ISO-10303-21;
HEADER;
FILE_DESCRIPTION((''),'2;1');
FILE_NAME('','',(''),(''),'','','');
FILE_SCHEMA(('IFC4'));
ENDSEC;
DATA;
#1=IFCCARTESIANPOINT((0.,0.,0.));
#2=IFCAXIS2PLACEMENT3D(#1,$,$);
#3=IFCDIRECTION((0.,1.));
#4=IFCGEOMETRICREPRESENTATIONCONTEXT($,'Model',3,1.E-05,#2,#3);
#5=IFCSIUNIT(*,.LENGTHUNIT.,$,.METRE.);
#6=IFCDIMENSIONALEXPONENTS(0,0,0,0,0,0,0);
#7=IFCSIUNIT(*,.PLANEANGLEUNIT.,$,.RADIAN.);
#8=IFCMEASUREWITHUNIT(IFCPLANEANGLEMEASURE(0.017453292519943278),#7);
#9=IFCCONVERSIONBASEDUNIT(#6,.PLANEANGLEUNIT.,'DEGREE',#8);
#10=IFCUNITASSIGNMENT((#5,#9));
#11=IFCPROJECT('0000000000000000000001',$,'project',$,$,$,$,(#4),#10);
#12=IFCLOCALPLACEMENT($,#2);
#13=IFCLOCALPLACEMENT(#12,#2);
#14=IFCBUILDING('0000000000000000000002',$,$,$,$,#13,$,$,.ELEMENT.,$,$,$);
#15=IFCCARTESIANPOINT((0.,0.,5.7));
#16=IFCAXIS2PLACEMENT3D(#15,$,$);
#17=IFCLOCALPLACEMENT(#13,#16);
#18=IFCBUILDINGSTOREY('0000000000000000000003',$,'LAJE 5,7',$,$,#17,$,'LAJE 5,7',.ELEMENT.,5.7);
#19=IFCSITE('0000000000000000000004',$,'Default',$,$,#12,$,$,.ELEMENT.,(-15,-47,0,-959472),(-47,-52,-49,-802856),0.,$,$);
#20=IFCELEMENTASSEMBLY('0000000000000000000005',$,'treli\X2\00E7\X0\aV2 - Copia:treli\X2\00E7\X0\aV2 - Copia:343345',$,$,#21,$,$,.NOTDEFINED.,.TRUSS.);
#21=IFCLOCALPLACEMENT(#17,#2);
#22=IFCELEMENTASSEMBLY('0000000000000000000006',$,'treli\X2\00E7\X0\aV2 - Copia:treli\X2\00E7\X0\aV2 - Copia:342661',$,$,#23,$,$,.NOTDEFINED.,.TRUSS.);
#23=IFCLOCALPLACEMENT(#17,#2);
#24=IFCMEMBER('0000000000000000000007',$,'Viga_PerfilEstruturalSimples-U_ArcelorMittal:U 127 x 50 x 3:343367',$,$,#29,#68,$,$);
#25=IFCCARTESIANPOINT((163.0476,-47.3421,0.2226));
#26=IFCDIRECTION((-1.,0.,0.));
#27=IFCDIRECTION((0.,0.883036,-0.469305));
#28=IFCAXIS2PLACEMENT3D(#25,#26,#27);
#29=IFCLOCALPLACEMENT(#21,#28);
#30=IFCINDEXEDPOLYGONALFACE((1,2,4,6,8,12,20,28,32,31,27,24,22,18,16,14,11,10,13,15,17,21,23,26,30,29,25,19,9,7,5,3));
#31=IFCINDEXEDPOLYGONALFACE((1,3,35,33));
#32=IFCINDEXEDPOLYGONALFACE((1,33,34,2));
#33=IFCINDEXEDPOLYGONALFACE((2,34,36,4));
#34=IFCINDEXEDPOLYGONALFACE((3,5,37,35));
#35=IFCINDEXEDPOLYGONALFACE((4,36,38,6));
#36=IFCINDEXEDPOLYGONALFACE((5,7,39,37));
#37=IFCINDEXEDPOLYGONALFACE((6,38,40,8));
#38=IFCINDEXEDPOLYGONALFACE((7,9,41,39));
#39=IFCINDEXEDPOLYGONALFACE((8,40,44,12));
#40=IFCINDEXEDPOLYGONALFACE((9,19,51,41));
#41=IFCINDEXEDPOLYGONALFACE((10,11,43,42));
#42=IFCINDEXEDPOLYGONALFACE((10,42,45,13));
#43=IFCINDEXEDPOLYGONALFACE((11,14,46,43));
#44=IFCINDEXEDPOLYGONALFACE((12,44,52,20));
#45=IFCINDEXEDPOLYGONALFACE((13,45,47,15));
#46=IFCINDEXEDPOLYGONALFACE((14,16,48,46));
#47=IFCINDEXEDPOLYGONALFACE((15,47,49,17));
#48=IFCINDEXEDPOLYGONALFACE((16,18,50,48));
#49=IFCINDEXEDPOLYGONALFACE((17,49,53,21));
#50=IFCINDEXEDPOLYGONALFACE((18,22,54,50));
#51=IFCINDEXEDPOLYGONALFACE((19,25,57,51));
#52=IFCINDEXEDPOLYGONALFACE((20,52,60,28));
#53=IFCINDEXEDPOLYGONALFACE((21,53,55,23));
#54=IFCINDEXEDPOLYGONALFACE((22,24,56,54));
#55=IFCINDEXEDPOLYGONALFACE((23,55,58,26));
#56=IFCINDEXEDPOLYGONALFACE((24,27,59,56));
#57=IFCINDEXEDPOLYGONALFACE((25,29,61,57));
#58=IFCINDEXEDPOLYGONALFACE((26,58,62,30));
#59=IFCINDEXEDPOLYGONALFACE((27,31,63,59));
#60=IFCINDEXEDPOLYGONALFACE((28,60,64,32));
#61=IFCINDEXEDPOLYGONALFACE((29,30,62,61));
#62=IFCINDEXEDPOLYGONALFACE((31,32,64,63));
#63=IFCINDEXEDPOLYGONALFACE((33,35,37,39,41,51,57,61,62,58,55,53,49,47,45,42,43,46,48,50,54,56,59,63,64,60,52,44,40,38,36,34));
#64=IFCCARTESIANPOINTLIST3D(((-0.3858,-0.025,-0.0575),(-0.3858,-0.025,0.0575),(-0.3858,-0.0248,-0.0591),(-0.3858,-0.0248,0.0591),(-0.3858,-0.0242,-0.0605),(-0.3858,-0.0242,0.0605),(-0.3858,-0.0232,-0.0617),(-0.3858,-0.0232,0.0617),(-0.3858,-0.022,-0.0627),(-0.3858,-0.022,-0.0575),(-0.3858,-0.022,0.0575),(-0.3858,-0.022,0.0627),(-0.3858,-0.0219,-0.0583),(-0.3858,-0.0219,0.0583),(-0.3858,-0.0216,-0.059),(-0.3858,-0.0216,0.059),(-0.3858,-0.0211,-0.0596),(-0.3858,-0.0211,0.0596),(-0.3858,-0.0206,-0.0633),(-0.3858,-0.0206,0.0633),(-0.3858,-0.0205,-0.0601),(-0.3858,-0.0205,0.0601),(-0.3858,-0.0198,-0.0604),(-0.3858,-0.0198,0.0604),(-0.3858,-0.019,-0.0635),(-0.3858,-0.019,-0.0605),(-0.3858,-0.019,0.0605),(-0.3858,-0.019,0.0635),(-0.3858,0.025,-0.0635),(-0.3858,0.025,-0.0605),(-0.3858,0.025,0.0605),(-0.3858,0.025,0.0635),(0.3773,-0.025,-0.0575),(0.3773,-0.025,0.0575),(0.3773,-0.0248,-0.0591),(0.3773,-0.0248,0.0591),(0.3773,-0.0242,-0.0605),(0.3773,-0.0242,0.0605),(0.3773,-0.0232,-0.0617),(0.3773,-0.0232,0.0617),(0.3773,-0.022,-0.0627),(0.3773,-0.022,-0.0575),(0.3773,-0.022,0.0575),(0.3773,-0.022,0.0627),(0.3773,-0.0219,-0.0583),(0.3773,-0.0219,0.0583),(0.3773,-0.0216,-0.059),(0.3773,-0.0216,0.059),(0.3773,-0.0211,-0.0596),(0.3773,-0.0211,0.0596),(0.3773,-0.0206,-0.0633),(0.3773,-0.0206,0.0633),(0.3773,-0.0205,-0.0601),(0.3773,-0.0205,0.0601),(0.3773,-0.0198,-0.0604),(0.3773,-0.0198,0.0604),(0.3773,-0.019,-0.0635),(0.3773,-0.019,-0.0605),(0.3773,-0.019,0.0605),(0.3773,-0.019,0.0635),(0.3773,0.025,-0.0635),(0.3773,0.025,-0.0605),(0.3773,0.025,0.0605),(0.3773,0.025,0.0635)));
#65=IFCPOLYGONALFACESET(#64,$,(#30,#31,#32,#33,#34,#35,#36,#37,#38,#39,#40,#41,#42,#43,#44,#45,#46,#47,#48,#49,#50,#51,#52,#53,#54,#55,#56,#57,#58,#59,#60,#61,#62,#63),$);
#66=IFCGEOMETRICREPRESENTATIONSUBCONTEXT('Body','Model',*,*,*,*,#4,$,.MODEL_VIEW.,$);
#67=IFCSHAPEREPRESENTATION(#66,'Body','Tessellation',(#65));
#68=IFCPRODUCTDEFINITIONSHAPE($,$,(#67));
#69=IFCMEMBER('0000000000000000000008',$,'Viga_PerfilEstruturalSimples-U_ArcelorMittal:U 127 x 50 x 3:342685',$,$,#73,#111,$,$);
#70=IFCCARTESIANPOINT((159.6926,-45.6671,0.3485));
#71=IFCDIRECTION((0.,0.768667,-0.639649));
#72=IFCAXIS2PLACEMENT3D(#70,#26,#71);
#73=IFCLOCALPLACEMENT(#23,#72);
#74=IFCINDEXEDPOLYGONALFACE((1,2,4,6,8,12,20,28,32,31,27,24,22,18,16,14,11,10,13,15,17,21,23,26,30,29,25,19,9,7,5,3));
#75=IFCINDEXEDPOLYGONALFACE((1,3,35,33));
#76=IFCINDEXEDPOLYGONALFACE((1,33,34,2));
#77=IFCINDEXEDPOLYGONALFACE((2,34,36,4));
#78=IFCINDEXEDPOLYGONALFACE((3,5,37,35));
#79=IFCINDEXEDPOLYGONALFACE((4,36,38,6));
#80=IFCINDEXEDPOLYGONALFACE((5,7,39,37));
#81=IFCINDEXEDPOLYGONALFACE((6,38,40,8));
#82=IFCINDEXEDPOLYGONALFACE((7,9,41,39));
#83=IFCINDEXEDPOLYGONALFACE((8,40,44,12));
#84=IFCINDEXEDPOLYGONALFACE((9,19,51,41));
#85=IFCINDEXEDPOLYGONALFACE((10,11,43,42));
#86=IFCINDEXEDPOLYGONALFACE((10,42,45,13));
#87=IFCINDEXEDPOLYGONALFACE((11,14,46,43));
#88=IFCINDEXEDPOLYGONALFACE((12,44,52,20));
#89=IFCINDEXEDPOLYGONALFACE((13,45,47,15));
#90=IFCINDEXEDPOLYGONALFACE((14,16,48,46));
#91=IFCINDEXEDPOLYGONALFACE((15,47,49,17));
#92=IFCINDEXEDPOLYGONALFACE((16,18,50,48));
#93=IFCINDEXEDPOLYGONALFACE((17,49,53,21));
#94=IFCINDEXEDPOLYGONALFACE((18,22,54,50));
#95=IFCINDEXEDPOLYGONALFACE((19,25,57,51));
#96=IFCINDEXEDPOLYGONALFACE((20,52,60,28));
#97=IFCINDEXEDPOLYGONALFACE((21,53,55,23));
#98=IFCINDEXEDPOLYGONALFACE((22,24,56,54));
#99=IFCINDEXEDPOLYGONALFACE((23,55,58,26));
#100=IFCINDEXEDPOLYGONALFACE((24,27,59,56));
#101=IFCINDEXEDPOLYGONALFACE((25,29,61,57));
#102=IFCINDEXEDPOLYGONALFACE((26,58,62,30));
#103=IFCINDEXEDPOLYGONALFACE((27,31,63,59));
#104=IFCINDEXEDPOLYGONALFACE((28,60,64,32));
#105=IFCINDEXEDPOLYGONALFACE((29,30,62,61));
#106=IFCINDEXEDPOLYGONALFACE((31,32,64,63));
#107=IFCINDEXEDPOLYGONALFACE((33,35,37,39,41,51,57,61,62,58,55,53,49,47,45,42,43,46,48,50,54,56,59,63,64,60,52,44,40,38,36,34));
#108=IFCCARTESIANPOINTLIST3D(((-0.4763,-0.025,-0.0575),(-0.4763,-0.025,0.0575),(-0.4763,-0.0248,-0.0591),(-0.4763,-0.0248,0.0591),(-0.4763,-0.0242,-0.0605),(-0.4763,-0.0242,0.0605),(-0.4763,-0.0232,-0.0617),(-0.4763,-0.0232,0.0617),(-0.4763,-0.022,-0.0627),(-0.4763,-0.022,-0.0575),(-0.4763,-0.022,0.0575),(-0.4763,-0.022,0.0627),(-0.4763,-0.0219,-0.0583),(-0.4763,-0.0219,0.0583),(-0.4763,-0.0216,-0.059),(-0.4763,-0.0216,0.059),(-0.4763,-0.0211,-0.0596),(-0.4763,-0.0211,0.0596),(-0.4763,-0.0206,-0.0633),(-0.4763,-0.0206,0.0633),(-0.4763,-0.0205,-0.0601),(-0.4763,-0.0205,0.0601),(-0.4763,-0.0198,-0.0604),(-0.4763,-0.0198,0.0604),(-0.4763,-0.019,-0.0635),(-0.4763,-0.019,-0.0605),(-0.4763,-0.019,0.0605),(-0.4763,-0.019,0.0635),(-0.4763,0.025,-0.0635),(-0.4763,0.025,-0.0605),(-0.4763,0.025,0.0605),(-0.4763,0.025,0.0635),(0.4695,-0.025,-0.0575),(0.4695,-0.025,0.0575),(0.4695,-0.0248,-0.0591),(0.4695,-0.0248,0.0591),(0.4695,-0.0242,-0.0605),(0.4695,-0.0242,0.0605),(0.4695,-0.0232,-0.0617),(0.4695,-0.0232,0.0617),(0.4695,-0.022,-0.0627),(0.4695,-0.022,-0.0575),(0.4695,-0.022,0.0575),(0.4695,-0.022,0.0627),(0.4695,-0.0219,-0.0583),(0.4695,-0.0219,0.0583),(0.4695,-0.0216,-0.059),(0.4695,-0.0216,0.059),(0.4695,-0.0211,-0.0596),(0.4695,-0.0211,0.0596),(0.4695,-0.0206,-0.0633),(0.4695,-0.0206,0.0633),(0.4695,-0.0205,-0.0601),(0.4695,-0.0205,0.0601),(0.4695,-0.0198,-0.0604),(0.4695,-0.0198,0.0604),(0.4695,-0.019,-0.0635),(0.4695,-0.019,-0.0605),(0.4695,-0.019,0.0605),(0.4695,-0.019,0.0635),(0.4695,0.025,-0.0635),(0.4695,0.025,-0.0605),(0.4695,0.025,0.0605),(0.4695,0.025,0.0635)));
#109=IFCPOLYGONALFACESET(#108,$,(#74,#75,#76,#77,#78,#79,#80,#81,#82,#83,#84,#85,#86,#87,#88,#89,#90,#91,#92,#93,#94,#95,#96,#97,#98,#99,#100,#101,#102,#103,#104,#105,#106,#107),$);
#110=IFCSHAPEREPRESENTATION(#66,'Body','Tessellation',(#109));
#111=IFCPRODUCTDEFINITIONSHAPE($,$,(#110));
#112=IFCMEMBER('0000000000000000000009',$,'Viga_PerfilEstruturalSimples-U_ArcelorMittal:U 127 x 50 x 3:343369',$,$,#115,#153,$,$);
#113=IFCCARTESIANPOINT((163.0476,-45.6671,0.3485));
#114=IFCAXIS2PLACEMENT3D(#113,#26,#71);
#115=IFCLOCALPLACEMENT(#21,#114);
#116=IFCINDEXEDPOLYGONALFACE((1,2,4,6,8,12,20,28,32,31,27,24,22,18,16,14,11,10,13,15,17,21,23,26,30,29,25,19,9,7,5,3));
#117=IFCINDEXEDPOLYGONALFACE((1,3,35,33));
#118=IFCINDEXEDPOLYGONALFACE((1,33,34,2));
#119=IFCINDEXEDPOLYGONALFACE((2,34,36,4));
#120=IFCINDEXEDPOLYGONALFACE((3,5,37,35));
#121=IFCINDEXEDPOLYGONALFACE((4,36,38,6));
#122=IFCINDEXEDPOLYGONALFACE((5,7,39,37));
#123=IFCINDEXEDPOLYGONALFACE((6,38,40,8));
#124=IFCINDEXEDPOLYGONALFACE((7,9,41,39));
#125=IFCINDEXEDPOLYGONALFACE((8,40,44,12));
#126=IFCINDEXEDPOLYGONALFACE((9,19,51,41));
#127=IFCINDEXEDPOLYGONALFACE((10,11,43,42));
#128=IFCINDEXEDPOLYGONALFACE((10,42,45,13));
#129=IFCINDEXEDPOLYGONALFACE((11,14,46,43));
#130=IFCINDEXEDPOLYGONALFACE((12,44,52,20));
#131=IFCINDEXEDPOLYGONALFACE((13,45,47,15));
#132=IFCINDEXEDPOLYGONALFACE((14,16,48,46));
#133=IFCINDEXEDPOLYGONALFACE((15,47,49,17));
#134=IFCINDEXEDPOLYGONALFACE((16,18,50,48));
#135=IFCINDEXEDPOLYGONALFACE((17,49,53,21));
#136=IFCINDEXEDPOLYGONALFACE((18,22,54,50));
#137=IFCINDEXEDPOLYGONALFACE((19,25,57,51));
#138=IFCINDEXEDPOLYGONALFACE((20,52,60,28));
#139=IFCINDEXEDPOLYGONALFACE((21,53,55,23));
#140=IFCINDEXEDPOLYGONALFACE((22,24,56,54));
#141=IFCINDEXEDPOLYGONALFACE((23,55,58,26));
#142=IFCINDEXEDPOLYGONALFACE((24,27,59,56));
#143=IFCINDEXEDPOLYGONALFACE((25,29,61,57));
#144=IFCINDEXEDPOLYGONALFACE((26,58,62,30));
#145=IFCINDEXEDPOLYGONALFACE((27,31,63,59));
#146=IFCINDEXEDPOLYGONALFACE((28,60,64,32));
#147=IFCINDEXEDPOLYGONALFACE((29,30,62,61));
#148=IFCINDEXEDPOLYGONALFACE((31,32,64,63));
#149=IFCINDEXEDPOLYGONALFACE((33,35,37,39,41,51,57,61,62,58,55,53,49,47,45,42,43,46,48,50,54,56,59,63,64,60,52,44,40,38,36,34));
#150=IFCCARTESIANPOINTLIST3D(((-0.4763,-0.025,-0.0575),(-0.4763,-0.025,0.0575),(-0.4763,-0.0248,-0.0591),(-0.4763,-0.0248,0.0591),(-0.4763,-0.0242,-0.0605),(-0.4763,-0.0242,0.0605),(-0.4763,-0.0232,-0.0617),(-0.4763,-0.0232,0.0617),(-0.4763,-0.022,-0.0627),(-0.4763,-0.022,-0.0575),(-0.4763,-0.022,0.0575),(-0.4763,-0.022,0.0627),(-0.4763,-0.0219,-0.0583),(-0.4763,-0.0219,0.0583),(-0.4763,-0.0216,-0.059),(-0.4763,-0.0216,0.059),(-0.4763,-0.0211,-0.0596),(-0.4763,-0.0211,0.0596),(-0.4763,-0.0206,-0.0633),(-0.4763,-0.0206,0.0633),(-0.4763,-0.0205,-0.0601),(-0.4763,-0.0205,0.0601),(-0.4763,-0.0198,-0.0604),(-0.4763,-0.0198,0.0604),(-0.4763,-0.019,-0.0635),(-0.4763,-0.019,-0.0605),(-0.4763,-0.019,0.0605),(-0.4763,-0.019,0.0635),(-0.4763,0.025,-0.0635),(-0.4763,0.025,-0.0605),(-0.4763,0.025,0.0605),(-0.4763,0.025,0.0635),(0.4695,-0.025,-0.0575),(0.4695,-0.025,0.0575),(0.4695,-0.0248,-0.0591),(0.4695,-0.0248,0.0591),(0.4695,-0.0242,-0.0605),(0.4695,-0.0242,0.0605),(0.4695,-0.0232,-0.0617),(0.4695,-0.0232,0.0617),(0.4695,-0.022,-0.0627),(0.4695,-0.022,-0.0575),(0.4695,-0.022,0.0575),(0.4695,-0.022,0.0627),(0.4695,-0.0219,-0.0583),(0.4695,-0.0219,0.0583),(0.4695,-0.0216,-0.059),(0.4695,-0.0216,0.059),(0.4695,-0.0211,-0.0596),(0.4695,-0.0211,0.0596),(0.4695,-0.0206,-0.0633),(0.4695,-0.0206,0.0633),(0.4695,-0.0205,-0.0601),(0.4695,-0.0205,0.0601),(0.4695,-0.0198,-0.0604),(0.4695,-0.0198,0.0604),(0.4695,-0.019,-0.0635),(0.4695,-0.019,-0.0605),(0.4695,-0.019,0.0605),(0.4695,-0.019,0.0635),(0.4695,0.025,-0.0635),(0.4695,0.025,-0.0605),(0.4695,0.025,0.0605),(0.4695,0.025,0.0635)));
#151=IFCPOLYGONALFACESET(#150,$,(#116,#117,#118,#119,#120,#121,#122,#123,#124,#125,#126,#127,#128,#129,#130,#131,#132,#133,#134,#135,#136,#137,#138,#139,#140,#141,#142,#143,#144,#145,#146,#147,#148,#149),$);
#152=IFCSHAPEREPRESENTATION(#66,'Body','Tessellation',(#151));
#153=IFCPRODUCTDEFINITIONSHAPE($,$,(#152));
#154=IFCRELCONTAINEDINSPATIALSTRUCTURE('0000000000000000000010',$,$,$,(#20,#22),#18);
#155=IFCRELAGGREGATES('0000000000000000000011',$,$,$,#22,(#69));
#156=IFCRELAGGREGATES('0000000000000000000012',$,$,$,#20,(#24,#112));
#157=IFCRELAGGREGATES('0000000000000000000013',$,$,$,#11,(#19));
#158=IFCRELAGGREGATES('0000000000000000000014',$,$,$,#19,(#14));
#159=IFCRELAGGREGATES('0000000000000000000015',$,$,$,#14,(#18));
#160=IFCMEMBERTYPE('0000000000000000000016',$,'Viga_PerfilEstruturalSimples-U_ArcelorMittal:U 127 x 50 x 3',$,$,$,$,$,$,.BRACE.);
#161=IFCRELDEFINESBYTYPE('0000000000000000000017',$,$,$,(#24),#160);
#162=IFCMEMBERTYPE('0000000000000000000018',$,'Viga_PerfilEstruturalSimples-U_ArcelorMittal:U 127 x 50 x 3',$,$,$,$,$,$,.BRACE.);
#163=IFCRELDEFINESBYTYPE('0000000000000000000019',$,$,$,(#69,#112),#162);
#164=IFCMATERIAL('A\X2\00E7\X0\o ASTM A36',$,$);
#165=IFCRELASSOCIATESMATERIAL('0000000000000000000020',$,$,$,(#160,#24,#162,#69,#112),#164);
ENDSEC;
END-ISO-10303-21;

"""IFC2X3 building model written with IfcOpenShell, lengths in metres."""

from ifc_helpers import new_model, entity, si_unit, converted_unit, direction, frame, frame_2d, origin, place, context, subcontext, project, spatial, polyline, circle_curve, parameter, trimmed, segment, composite_curve, outline, extrude, source, transform, mapped, material, type_object, type_shapes, element, aggregate, save


model = new_model("IFC2X3")

# Units and contexts
model_context = context("Model", 3, precision=1e-05, world=origin(), true_north=direction((0.0, 1.0)))
body_context = subcontext(model_context, "Body", "Model", "MODEL_VIEW")
ifc_project = project(units=[si_unit("LENGTHUNIT", "METRE"), converted_unit("PLANEANGLEUNIT", "DEGREE", entity("IfcPlaneAngleMeasure", 0.017453292519943278), si_unit("PLANEANGLEUNIT", "RADIAN"), dimensions=[0, 0, 0, 0, 0, 0, 0])], contexts=[model_context])

# Site, building, storey
site_placement = place(None, origin())
site = spatial("IfcSite", under=ifc_project, at=site_placement, Name="Default", CompositionType="ELEMENT", RefLatitude=(-15, -47, 0, -959472), RefLongitude=(-47, -52, -49, -802856), RefElevation=0.0)
building_placement = place(site_placement, origin())
building = spatial("IfcBuilding", under=site, at=building_placement, CompositionType="ELEMENT")
storey_placement = place(building_placement, frame((0.0, 0.0, 5.7)))
storey = spatial("IfcBuildingStorey", under=building, at=storey_placement, Name="LAJE 5,7", LongName="LAJE 5,7", CompositionType="ELEMENT", Elevation=5.7)

# Element assembly
assembly_1_placement = place(storey_placement, origin())
assembly_1 = element("IfcElementAssembly", 1, at=assembly_1_placement, inside=storey, Name="treliçaV2 - Copia:treliçaV2 - Copia:343345", AssemblyPlace="NOTDEFINED", PredefinedType="TRUSS")
ifc_material = material(Name="Aço ASTM A36")

# Element assembly
assembly_2_placement = place(storey_placement, origin())
assembly_2 = element("IfcElementAssembly", 2, at=assembly_2_placement, inside=storey, Name="treliçaV2 - Copia:treliçaV2 - Copia:342661", AssemblyPlace="NOTDEFINED", PredefinedType="TRUSS")

# Members
member_type_1 = type_object("IfcMemberType", Name="Viga_PerfilEstruturalSimples-U_ArcelorMittal:U 127 x 50 x 3", PredefinedType="BRACE", material=ifc_material)
shared_shape_1 = source(origin(), body_context, "Body", "SweptSolid", [
    extrude(outline(composite_curve([segment(polyline([(-0.0575, -0.0192), (0.0575, -0.0192)]), True, "CONTINUOUS"), segment(trimmed(circle_curve(frame_2d((0.0575, -0.0132), x_axis=(0.0, 1.0)), 0.006), [parameter(180.0)], [parameter(270.0)], True, "PARAMETER"), True, "CONTINUOUS"), segment(polyline([(0.0635, -0.0132), (0.0635, 0.0308)]), True, "CONTINUOUS"), segment(polyline([(0.0635, 0.0308), (0.0605, 0.0308)]), True, "CONTINUOUS"), segment(polyline([(0.0605, 0.0308), (0.0605, -0.0132)]), True, "CONTINUOUS"), segment(trimmed(circle_curve(frame_2d((0.0575, -0.0132), x_axis=(0.0, 1.0)), 0.003), [parameter(180.0)], [parameter(270.0)], True, "PARAMETER"), False, "CONTINUOUS"), segment(polyline([(0.0575, -0.0162), (-0.0575, -0.0162)]), True, "CONTINUOUS"), segment(trimmed(circle_curve(frame_2d((-0.0575, -0.0132), x_axis=(0.0, 1.0)), 0.003), [parameter(90.0)], [parameter(180.0)], True, "PARAMETER"), False, "CONTINUOUS"), segment(polyline([(-0.0605, -0.0132), (-0.0605, 0.0308)]), True, "CONTINUOUS"), segment(polyline([(-0.0605, 0.0308), (-0.0635, 0.0308)]), True, "CONTINUOUS"), segment(polyline([(-0.0635, 0.0308), (-0.0635, -0.0132)]), True, "CONTINUOUS"), segment(trimmed(circle_curve(frame_2d((-0.0575, -0.0132), x_axis=(0.0, 1.0)), 0.006), [parameter(90.0)], [parameter(180.0)], True, "PARAMETER"), True, "CONTINUOUS")], self_intersect=False)), frame((-0.3858, -0.0058, 0.0), z_axis=(1.0, 0.0, 0.0), x_axis=(0.0, 0.0, -1.0)), (0.0, 0.0, 1.0), 0.7631),
])
type_shapes(member_type_1, [shared_shape_1])
member_1_placement = place(assembly_1_placement, frame((163.0476, -47.3421, 0.2226), z_axis=(-1.0, 0.0, 0.0), x_axis=(0.0, 0.883036, -0.469305)))
member_1 = element("IfcMember", 3, at=member_1_placement, type_object=member_type_1, material=ifc_material, Name="Viga_PerfilEstruturalSimples-U_ArcelorMittal:U 127 x 50 x 3:343367", context=body_context, shape_type="MappedRepresentation", body=[
    mapped(shared_shape_1, transform((0.0, 0.0, 0.0), scale=1.0)),
])
member_type_2 = type_object("IfcMemberType", Name="Viga_PerfilEstruturalSimples-U_ArcelorMittal:U 127 x 50 x 3", PredefinedType="BRACE", material=ifc_material)
shared_shape_2 = source(origin(), body_context, "Body", "SweptSolid", [
    extrude(outline(composite_curve([segment(polyline([(-0.0575, -0.0192), (0.0575, -0.0192)]), True, "CONTINUOUS"), segment(trimmed(circle_curve(frame_2d((0.0575, -0.0132), x_axis=(0.0, 1.0)), 0.006), [parameter(180.0)], [parameter(270.0)], True, "PARAMETER"), True, "CONTINUOUS"), segment(polyline([(0.0635, -0.0132), (0.0635, 0.0308)]), True, "CONTINUOUS"), segment(polyline([(0.0635, 0.0308), (0.0605, 0.0308)]), True, "CONTINUOUS"), segment(polyline([(0.0605, 0.0308), (0.0605, -0.0132)]), True, "CONTINUOUS"), segment(trimmed(circle_curve(frame_2d((0.0575, -0.0132), x_axis=(0.0, 1.0)), 0.003), [parameter(180.0)], [parameter(270.0)], True, "PARAMETER"), False, "CONTINUOUS"), segment(polyline([(0.0575, -0.0162), (-0.0575, -0.0162)]), True, "CONTINUOUS"), segment(trimmed(circle_curve(frame_2d((-0.0575, -0.0132), x_axis=(0.0, 1.0)), 0.003), [parameter(90.0)], [parameter(180.0)], True, "PARAMETER"), False, "CONTINUOUS"), segment(polyline([(-0.0605, -0.0132), (-0.0605, 0.0308)]), True, "CONTINUOUS"), segment(polyline([(-0.0605, 0.0308), (-0.0635, 0.0308)]), True, "CONTINUOUS"), segment(polyline([(-0.0635, 0.0308), (-0.0635, -0.0132)]), True, "CONTINUOUS"), segment(trimmed(circle_curve(frame_2d((-0.0575, -0.0132), x_axis=(0.0, 1.0)), 0.006), [parameter(90.0)], [parameter(180.0)], True, "PARAMETER"), True, "CONTINUOUS")], self_intersect=False)), frame((-0.4763, -0.0058, 0.0), z_axis=(1.0, 0.0, 0.0), x_axis=(0.0, 0.0, -1.0)), (0.0, 0.0, 1.0), 0.9459),
])
type_shapes(member_type_2, [shared_shape_2])
member_2_placement = place(assembly_2_placement, frame((159.6926, -45.6671, 0.3485), z_axis=(-1.0, 0.0, 0.0), x_axis=(0.0, 0.768667, -0.639649)))
member_2 = element("IfcMember", 4, at=member_2_placement, type_object=member_type_2, material=ifc_material, Name="Viga_PerfilEstruturalSimples-U_ArcelorMittal:U 127 x 50 x 3:342685", context=body_context, shape_type="MappedRepresentation", body=[
    mapped(shared_shape_2, transform((0.0, 0.0, 0.0), scale=1.0)),
])
member_3_placement = place(assembly_1_placement, frame((163.0476, -45.6671, 0.3485), z_axis=(-1.0, 0.0, 0.0), x_axis=(0.0, 0.768667, -0.639649)))
member_3 = element("IfcMember", 5, at=member_3_placement, type_object=member_type_2, material=ifc_material, Name="Viga_PerfilEstruturalSimples-U_ArcelorMittal:U 127 x 50 x 3:343369", context=body_context, shape_type="MappedRepresentation", body=[
    mapped(shared_shape_2, transform((0.0, 0.0, 0.0), scale=1.0)),
])
aggregate(assembly_2, [member_2])
aggregate(assembly_1, [member_1, member_3])

save(model, "model.ifc")
